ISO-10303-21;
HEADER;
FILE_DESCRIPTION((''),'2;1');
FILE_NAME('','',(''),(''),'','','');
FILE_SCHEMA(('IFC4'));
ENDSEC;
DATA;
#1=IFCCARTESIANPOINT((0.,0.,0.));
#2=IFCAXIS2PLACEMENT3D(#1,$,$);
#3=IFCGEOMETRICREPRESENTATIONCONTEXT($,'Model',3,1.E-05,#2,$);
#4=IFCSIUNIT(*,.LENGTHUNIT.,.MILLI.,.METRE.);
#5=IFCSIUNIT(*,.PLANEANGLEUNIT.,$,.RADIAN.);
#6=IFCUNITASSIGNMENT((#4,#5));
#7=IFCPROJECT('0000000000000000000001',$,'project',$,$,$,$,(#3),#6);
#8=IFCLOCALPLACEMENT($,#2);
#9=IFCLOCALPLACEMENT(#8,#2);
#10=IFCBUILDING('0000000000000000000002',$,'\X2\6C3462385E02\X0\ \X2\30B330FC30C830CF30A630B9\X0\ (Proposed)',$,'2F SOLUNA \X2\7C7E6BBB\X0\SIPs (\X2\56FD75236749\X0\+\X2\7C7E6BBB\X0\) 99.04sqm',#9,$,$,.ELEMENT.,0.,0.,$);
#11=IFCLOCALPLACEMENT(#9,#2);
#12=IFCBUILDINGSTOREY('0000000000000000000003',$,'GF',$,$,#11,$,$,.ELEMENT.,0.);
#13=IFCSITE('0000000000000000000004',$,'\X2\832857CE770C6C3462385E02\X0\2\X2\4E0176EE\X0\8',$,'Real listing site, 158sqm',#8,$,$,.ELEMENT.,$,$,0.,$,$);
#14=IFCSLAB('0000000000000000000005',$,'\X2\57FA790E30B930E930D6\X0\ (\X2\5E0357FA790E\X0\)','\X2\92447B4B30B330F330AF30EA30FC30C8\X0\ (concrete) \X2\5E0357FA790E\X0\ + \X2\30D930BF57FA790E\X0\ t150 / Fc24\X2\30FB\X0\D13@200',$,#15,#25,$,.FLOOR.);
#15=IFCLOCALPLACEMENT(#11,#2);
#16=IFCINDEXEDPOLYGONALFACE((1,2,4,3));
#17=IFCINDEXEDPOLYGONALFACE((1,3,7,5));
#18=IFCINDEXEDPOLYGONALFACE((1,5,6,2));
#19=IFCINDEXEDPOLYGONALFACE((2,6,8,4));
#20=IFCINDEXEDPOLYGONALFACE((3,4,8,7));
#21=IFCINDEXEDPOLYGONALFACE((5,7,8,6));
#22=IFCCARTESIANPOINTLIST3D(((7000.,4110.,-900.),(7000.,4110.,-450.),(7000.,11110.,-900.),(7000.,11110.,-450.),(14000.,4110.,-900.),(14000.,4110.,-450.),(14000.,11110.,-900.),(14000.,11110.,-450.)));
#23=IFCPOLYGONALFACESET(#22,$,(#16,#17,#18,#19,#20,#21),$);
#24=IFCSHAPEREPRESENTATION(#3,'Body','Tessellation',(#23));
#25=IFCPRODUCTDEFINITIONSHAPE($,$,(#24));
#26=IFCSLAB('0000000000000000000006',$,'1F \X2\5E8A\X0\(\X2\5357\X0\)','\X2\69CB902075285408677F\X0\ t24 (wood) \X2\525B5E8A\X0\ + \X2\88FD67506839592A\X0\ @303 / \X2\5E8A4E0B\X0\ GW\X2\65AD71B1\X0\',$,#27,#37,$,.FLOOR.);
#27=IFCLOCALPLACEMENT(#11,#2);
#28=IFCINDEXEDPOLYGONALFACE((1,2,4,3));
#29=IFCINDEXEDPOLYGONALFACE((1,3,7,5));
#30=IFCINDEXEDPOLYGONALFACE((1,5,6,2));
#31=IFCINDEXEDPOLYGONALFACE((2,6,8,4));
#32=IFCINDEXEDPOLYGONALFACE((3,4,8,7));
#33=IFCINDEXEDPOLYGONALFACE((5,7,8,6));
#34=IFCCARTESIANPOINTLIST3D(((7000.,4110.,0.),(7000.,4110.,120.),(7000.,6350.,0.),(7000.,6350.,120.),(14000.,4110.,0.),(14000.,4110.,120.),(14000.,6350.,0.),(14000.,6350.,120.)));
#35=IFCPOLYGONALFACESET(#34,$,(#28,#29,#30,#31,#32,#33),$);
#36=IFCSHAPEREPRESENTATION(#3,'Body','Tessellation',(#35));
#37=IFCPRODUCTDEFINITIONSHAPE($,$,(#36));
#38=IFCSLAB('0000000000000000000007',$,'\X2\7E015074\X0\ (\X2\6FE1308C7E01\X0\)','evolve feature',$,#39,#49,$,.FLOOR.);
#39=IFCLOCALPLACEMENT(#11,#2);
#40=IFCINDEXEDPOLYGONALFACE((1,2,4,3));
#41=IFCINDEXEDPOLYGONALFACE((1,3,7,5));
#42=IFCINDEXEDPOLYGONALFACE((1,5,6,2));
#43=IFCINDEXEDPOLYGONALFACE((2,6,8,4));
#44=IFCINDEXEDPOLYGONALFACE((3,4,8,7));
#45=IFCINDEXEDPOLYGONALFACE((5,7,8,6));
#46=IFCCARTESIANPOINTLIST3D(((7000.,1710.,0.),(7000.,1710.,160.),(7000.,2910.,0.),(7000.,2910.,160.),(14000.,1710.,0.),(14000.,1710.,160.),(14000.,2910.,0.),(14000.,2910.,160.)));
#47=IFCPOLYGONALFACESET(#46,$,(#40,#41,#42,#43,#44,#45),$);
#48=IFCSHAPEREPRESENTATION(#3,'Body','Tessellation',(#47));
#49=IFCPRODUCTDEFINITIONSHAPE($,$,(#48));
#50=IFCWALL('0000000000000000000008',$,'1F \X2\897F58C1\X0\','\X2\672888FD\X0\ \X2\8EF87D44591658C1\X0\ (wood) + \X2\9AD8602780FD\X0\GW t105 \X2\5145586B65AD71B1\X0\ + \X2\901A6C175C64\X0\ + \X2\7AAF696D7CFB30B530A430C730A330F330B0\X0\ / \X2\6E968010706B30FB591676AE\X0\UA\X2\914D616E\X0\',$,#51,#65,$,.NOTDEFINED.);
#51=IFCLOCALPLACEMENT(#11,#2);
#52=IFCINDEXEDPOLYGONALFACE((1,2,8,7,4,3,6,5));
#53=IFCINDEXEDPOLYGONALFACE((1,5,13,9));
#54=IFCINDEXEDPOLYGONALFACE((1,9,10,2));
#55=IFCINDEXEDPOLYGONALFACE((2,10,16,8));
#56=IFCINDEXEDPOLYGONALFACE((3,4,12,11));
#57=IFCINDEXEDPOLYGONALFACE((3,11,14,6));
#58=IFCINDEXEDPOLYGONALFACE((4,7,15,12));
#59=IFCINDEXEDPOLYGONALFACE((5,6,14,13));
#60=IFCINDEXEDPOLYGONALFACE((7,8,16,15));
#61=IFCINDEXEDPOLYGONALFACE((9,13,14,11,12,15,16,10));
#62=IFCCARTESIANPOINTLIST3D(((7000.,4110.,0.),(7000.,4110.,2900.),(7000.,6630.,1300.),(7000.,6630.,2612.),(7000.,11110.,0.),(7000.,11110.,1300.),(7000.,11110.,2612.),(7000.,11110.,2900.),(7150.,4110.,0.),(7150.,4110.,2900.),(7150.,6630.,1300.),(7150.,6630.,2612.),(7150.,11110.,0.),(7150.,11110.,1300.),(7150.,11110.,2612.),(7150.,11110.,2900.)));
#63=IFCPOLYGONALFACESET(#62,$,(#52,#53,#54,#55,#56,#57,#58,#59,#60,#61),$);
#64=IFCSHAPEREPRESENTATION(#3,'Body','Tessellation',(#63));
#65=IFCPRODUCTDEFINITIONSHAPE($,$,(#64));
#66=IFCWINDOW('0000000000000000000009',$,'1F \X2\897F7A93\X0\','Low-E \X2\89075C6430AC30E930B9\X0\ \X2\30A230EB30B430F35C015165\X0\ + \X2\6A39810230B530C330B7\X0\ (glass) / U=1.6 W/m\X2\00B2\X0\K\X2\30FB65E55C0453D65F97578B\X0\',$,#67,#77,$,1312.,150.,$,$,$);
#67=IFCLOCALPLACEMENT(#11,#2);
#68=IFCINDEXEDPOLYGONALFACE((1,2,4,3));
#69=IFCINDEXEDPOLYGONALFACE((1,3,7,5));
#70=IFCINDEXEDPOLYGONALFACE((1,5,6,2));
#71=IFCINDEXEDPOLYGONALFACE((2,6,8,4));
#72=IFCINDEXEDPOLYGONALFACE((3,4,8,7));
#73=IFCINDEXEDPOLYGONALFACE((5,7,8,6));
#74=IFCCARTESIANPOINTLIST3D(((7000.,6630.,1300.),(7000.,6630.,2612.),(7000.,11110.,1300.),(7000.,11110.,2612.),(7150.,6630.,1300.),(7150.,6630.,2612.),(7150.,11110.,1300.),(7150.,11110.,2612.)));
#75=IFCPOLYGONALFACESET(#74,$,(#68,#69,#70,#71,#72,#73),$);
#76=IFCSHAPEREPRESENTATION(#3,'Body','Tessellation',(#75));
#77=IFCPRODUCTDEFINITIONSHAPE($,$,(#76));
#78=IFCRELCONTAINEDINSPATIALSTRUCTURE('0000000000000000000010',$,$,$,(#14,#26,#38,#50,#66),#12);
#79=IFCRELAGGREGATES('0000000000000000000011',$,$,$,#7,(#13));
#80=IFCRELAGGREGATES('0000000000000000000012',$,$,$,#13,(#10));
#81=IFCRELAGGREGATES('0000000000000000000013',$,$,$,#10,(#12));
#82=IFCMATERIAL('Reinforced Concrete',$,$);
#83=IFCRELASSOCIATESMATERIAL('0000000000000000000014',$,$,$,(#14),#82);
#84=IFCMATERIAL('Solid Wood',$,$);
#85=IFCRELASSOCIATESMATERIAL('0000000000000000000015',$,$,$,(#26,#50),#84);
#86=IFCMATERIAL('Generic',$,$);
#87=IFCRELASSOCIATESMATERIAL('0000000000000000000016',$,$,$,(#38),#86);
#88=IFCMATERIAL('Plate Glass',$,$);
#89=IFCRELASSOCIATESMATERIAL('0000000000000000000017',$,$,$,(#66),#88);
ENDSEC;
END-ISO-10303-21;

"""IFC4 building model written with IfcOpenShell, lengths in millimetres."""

from ifc_helpers import new_model, si_unit, frame, frame_2d, origin, place, context, project, spatial, rectangle, extrude, material, element, fill, save


model = new_model("IFC4")

# Units and contexts
model_context = context("Model", 3, precision=1e-05, world=origin())
ifc_project = project(units=[si_unit("LENGTHUNIT", "METRE", prefix="MILLI"), si_unit("PLANEANGLEUNIT", "RADIAN")], contexts=[model_context])

# Site, building, storey
site_placement = place(None, origin())
site = spatial("IfcSite", under=ifc_project, at=site_placement, Name="茨城県水戸市2丁目8", ObjectType="Real listing site, 158sqm", CompositionType="ELEMENT", RefElevation=0.0)
building_placement = place(site_placement, origin())
building = spatial("IfcBuilding", under=site, at=building_placement, Name="水戸市 コートハウス (Proposed)", ObjectType="2F SOLUNA 籾殻SIPs (国産杉+籾殻) 99.04sqm", CompositionType="ELEMENT", ElevationOfRefHeight=0.0, ElevationOfTerrain=0.0)
storey_placement = place(building_placement, origin())
storey = spatial("IfcBuildingStorey", under=building, at=storey_placement, Name="GF", CompositionType="ELEMENT", Elevation=0.0)

# Slabs
ifc_material_1 = material(Name="Reinforced Concrete")
slab_1_placement = place(storey_placement, frame((3500.0, 2055.0, -450.0)))
element("IfcSlab", 1, at=slab_1_placement, inside=storey, material=ifc_material_1, Name="基礎スラブ (布基礎)", Description="鉄筋コンクリート (concrete) 布基礎 + ベタ基礎 t150 / Fc24・D13@200", PredefinedType="FLOOR", context=model_context, shape_type="SweptSolid", body=[
    extrude(rectangle(XDim=7000.0, YDim=7000.0, at=frame_2d((3500.0, 3500.0))), frame((3500.0, 2055.0, -450.0)), (0.0, 0.0, 1.0), 450.0),
])
ifc_material_2 = material(Name="Solid Wood")
slab_2_placement = place(storey_placement, frame((3500.0, 2055.0, 0.0)))
element("IfcSlab", 2, at=slab_2_placement, inside=storey, material=ifc_material_2, Name="1F 床(南)", Description="構造用合板 t24 (wood) 剛床 + 製材根太 @303 / 床下 GW断熱", PredefinedType="FLOOR", context=model_context, shape_type="SweptSolid", body=[
    extrude(rectangle(XDim=7000.0, YDim=2240.0, at=frame_2d((3500.0, 1120.0))), frame((3500.0, 2055.0, 0.0)), (0.0, 0.0, 1.0), 120.0),
])
ifc_material_3 = material(Name="Generic")
slab_3_placement = place(storey_placement, frame((3500.0, 855.0, 0.0)))
element("IfcSlab", 3, at=slab_3_placement, inside=storey, material=ifc_material_3, Name="縁側 (濡れ縁)", Description="evolve feature", PredefinedType="FLOOR", context=model_context, shape_type="SweptSolid", body=[
    extrude(rectangle(XDim=7000.0, YDim=1200.0, at=frame_2d((3500.0, 600.0))), frame((3500.0, 855.0, 0.0)), (0.0, 0.0, 1.0), 160.0),
])

# Shared definitions
ifc_material_4 = material(Name="Plate Glass")

# Wall, opening, window
wall_1_placement = place(storey_placement, frame((3500.0, 2055.0, 0.0)))
wall_1 = element("IfcWall", 4, at=wall_1_placement, inside=storey, material=ifc_material_2, Name="1F 西壁", Description="木製 軸組外壁 (wood) + 高性能GW t105 充填断熱 + 通気層 + 窯業系サイディング / 準耐火・外皮UA配慮", PredefinedType="NOTDEFINED", context=model_context, shape_type="SweptSolid", body=[
    extrude(rectangle(XDim=150.0, YDim=7000.0, at=frame_2d((75.0, 3500.0))), frame((3500.0, 2055.0, 0.0)), (0.0, 0.0, 1.0), 2900.0),
])
opening_1_placement = place(storey_placement, frame((3500.0, 3315.0, 650.0)))
opening_1 = element("IfcOpeningElement", 5, at=opening_1_placement, cuts=wall_1, PredefinedType="NOTDEFINED", context=model_context, shape_type="SweptSolid", body=[
    extrude(rectangle(XDim=150.0, YDim=4480.0, at=frame_2d((75.0, 2240.0))), frame((3500.0, 3315.0, 650.0)), (0.0, 0.0, 1.0), 1312.0),
])
window_1_placement = place(storey_placement, frame((3500.0, 3315.0, 650.0)))
window_1 = element("IfcWindow", 6, at=window_1_placement, inside=storey, material=ifc_material_4, Name="1F 西窓", Description="Low-E 複層ガラス アルゴン封入 + 樹脂サッシ (glass) / U=1.6 W/m²K・日射取得型", OverallHeight=1312.0, OverallWidth=150.0, context=model_context, shape_type="SweptSolid", body=[
    extrude(rectangle(XDim=150.0, YDim=4480.0, at=frame_2d((75.0, 2240.0))), frame((3500.0, 3315.0, 650.0)), (0.0, 0.0, 1.0), 1312.0),
])
fill(opening_1, window_1)

save(model, "model.ifc")
